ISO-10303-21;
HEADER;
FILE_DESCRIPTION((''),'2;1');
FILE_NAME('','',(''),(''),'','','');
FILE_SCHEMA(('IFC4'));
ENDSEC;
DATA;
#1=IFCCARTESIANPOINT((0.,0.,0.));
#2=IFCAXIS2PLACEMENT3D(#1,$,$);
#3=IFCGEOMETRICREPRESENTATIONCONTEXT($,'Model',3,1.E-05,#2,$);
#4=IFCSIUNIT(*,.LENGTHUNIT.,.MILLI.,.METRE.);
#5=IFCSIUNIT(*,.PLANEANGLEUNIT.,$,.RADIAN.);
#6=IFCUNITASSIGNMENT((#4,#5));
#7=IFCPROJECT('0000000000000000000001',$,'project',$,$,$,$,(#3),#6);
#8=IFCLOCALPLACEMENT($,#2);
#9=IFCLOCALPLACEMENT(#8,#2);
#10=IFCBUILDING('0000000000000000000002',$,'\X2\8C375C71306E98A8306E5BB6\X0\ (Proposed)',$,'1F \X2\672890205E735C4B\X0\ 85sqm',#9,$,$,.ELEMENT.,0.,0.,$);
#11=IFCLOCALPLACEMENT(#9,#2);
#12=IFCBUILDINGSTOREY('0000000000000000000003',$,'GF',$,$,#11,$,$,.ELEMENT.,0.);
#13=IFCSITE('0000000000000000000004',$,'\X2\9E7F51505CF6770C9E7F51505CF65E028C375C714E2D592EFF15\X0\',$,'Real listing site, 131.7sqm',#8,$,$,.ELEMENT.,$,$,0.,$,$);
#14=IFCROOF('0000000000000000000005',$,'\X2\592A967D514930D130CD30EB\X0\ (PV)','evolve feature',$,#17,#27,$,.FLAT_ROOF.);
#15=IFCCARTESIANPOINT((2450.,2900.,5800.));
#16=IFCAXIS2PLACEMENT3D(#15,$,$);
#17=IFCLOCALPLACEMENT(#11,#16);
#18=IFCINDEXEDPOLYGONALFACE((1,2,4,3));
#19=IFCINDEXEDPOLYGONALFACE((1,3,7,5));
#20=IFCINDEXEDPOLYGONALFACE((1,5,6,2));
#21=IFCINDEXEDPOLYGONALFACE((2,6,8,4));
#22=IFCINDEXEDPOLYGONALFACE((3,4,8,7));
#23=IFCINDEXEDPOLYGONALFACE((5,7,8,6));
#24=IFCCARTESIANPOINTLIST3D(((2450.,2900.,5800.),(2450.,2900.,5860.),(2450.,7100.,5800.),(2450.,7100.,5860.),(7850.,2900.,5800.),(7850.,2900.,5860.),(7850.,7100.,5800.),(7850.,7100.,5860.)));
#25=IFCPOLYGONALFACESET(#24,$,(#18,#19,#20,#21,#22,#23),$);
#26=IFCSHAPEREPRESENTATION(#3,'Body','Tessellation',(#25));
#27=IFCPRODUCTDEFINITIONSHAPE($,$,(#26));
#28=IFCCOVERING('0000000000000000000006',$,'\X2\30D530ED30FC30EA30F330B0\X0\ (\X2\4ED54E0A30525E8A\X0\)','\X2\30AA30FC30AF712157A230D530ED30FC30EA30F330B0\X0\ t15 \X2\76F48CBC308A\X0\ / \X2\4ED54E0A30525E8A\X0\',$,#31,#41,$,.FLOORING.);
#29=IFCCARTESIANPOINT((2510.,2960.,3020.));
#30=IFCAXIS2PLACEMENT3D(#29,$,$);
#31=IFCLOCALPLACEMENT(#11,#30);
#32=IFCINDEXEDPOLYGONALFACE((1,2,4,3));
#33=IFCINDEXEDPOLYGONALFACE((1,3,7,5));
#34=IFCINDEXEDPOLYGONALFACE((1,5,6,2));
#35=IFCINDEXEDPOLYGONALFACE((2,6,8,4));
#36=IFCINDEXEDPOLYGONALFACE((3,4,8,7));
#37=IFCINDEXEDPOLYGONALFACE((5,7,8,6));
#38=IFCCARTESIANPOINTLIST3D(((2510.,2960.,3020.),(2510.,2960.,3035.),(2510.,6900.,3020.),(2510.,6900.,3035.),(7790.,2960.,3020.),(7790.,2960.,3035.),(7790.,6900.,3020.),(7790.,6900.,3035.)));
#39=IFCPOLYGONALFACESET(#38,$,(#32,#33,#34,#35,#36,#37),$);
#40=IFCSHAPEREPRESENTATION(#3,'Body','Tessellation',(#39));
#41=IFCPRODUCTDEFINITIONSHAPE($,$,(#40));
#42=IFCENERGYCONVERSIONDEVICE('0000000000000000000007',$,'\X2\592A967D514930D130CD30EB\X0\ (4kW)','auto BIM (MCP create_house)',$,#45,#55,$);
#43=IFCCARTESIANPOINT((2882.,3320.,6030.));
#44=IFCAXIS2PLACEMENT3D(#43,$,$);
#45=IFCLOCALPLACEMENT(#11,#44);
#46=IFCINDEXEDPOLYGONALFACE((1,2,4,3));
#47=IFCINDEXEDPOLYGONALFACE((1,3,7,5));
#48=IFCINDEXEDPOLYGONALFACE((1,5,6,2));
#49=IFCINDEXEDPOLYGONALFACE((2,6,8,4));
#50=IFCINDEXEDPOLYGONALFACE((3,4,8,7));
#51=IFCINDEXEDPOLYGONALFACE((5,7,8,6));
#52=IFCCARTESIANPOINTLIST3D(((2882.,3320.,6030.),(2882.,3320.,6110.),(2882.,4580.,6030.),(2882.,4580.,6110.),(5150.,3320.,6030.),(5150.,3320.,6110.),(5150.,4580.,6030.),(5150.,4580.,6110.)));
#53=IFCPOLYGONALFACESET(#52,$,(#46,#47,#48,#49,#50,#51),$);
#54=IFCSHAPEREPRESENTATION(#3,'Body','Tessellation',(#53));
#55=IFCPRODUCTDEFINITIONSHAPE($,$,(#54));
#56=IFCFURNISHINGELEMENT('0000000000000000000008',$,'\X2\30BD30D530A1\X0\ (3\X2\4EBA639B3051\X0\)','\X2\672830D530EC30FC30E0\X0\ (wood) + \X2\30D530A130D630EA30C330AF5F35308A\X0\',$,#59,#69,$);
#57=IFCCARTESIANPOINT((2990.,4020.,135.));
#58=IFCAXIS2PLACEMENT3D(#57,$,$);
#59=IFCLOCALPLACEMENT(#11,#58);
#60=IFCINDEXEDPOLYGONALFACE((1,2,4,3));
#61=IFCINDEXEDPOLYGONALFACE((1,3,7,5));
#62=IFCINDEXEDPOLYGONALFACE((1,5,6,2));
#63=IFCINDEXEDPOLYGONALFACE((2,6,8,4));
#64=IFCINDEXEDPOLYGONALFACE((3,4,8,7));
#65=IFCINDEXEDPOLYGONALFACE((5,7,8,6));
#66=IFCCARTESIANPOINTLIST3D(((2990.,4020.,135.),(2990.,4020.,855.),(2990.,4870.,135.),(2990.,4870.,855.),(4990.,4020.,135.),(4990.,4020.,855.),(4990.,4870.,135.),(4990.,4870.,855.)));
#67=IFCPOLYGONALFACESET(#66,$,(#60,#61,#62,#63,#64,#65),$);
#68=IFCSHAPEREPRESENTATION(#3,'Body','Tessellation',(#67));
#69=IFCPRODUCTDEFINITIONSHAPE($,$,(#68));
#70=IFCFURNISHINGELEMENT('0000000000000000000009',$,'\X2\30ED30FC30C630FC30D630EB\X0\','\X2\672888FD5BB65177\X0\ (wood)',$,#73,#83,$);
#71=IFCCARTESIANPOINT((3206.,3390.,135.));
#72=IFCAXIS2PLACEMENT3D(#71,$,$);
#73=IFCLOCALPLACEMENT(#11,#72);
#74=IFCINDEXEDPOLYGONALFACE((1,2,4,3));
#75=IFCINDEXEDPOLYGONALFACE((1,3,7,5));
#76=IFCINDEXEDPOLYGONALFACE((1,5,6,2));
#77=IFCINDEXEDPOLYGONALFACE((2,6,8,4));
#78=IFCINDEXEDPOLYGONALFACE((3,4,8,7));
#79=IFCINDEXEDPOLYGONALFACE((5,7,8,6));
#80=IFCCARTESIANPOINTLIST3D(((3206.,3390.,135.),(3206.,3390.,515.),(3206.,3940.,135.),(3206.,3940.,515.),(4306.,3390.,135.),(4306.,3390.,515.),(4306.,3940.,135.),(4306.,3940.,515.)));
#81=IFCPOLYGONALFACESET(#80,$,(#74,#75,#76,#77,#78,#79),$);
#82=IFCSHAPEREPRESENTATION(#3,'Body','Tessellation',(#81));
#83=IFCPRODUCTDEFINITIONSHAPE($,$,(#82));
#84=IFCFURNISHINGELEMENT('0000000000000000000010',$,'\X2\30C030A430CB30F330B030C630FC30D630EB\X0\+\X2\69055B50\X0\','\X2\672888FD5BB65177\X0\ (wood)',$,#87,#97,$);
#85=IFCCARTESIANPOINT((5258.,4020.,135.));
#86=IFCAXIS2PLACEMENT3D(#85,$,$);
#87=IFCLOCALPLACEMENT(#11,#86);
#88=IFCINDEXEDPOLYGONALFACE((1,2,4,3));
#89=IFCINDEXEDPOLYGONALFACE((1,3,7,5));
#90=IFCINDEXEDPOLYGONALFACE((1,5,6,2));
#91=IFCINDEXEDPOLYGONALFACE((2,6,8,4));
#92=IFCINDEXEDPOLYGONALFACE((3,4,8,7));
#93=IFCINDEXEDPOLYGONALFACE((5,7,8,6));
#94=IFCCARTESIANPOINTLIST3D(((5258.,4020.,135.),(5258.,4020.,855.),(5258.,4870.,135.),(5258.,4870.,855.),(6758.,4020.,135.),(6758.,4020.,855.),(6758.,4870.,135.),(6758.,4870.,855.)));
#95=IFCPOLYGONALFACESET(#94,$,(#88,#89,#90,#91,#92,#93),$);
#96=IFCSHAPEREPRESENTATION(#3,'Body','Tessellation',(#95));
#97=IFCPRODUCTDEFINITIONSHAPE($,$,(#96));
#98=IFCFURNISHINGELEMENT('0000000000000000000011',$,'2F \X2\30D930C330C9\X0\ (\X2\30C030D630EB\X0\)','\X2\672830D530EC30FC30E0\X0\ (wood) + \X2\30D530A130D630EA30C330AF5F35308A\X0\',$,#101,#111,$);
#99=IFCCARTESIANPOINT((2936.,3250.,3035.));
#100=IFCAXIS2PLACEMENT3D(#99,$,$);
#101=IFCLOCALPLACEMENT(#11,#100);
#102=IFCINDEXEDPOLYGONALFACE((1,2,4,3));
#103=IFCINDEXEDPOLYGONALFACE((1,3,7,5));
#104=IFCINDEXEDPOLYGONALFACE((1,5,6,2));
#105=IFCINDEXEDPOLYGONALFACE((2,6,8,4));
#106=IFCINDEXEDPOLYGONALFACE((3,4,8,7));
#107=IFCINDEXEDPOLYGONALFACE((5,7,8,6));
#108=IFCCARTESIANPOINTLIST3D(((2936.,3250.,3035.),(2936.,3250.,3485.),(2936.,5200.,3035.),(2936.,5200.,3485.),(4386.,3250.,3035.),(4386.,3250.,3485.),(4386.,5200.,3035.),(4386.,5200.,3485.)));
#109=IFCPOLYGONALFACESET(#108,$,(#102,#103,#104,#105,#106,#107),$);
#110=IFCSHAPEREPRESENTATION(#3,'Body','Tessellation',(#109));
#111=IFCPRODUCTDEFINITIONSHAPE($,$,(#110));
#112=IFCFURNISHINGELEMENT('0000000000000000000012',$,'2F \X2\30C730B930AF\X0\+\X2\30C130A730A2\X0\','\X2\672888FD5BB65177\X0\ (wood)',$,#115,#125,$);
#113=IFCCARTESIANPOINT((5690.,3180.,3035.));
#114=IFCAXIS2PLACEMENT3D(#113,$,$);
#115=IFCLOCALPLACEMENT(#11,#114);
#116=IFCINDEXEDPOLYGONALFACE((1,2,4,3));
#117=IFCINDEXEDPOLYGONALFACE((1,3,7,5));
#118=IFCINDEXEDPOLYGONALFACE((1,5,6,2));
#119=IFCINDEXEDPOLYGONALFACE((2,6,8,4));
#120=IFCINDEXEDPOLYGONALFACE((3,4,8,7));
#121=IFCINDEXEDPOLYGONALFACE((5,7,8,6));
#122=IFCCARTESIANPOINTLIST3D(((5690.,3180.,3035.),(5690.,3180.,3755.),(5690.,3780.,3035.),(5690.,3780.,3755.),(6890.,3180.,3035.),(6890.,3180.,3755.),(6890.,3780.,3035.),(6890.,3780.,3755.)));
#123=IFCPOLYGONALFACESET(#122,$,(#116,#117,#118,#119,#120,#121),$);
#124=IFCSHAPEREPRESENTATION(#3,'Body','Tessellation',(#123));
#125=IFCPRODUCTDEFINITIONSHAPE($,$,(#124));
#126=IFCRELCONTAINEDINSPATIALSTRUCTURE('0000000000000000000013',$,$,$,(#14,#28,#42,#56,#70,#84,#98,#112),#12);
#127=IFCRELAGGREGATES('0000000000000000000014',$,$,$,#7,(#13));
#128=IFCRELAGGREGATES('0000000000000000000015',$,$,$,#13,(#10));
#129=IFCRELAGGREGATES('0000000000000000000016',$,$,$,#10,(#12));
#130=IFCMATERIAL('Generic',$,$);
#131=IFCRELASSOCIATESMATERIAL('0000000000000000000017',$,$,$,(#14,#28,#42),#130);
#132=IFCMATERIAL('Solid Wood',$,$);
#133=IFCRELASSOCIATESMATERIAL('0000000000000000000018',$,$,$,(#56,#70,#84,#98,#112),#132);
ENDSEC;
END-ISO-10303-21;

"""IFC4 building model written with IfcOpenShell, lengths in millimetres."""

from ifc_helpers import new_model, si_unit, frame, frame_2d, origin, place, context, project, spatial, rectangle, extrude, material, element, save


model = new_model("IFC4")

# Units and contexts
model_context = context("Model", 3, precision=1e-05, world=origin())
ifc_project = project(units=[si_unit("LENGTHUNIT", "METRE", prefix="MILLI"), si_unit("PLANEANGLEUNIT", "RADIAN")], contexts=[model_context])

# Site, building, storey
site_placement = place(None, origin())
site = spatial("IfcSite", under=ifc_project, at=site_placement, Name="鹿児島県鹿児島市谷山中央５", ObjectType="Real listing site, 131.7sqm", CompositionType="ELEMENT", RefElevation=0.0)
building_placement = place(site_placement, origin())
building = spatial("IfcBuilding", under=site, at=building_placement, Name="谷山の風の家 (Proposed)", ObjectType="1F 木造平屋 85sqm", CompositionType="ELEMENT", ElevationOfRefHeight=0.0, ElevationOfTerrain=0.0)
storey_placement = place(building_placement, origin())
storey = spatial("IfcBuildingStorey", under=building, at=storey_placement, Name="GF", CompositionType="ELEMENT", Elevation=0.0)

# Shared definitions
ifc_material_1 = material(Name="Solid Wood")

# Shared definitions
ifc_material_2 = material(Name="Generic")

# Roof
roof_placement = place(storey_placement, frame((2450.0, 2900.0, 5800.0)))
element("IfcRoof", 1, at=roof_placement, inside=storey, material=ifc_material_2, Name="太陽光パネル (PV)", Description="evolve feature", PredefinedType="FLAT_ROOF", context=model_context, shape_type="SweptSolid", body=[
    extrude(rectangle(XDim=5400.0, YDim=4200.0, at=frame_2d((2700.0, 2100.0))), frame((2450.0, 2900.0, 5800.0)), (0.0, 0.0, 1.0), 60.0),
])

# Covering
covering_placement = place(storey_placement, frame((2510.0, 2960.0, 3020.0)))
element("IfcCovering", 2, at=covering_placement, inside=storey, material=ifc_material_2, Name="フローリング (仕上げ床)", Description="オーク無垢フローリング t15 直貼り / 仕上げ床", PredefinedType="FLOORING", context=model_context, shape_type="SweptSolid", body=[
    extrude(rectangle(XDim=5280.0, YDim=3940.0, at=frame_2d((2640.0, 1970.0))), frame((2510.0, 2960.0, 3020.0)), (0.0, 0.0, 1.0), 15.0),
])

# Energy conversion device
energy_conversion_device_placement = place(storey_placement, frame((2882.0, 3320.0, 6030.0)))
element("IfcEnergyConversionDevice", 3, at=energy_conversion_device_placement, inside=storey, material=ifc_material_2, Name="太陽光パネル (4kW)", Description="auto BIM (MCP create_house)", context=model_context, shape_type="SweptSolid", body=[
    extrude(rectangle(XDim=2268.0, YDim=1260.0, at=frame_2d((1134.0, 630.0))), frame((2882.0, 3320.0, 6030.0)), (0.0, 0.0, 1.0), 80.0),
])

# Furnishing elements
furnishing_1_placement = place(storey_placement, frame((2990.0, 4020.0, 135.0)))
element("IfcFurnishingElement", 4, at=furnishing_1_placement, inside=storey, material=ifc_material_1, Name="ソファ (3人掛け)", Description="木フレーム (wood) + ファブリック張り", context=model_context, shape_type="SweptSolid", body=[
    extrude(rectangle(XDim=2000.0, YDim=850.0, at=frame_2d((1000.0, 425.0))), frame((2990.0, 4020.0, 135.0)), (0.0, 0.0, 1.0), 720.0),
])
furnishing_2_placement = place(storey_placement, frame((3206.0, 3390.0, 135.0)))
element("IfcFurnishingElement", 5, at=furnishing_2_placement, inside=storey, material=ifc_material_1, Name="ローテーブル", Description="木製家具 (wood)", context=model_context, shape_type="SweptSolid", body=[
    extrude(rectangle(XDim=1100.0, YDim=550.0, at=frame_2d((550.0, 275.0))), frame((3206.0, 3390.0, 135.0)), (0.0, 0.0, 1.0), 380.0),
])
furnishing_3_placement = place(storey_placement, frame((5258.0, 4020.0, 135.0)))
element("IfcFurnishingElement", 6, at=furnishing_3_placement, inside=storey, material=ifc_material_1, Name="ダイニングテーブル+椅子", Description="木製家具 (wood)", context=model_context, shape_type="SweptSolid", body=[
    extrude(rectangle(XDim=1500.0, YDim=850.0, at=frame_2d((750.0, 425.0))), frame((5258.0, 4020.0, 135.0)), (0.0, 0.0, 1.0), 720.0),
])
furnishing_4_placement = place(storey_placement, frame((2936.0, 3250.0, 3035.0)))
element("IfcFurnishingElement", 7, at=furnishing_4_placement, inside=storey, material=ifc_material_1, Name="2F ベッド (ダブル)", Description="木フレーム (wood) + ファブリック張り", context=model_context, shape_type="SweptSolid", body=[
    extrude(rectangle(XDim=1450.0, YDim=1950.0, at=frame_2d((725.0, 975.0))), frame((2936.0, 3250.0, 3035.0)), (0.0, 0.0, 1.0), 450.0),
])
furnishing_5_placement = place(storey_placement, frame((5690.0, 3180.0, 3035.0)))
element("IfcFurnishingElement", 8, at=furnishing_5_placement, inside=storey, material=ifc_material_1, Name="2F デスク+チェア", Description="木製家具 (wood)", context=model_context, shape_type="SweptSolid", body=[
    extrude(rectangle(XDim=1200.0, YDim=600.0, at=frame_2d((600.0, 300.0))), frame((5690.0, 3180.0, 3035.0)), (0.0, 0.0, 1.0), 720.0),
])

save(model, "model.ifc")
